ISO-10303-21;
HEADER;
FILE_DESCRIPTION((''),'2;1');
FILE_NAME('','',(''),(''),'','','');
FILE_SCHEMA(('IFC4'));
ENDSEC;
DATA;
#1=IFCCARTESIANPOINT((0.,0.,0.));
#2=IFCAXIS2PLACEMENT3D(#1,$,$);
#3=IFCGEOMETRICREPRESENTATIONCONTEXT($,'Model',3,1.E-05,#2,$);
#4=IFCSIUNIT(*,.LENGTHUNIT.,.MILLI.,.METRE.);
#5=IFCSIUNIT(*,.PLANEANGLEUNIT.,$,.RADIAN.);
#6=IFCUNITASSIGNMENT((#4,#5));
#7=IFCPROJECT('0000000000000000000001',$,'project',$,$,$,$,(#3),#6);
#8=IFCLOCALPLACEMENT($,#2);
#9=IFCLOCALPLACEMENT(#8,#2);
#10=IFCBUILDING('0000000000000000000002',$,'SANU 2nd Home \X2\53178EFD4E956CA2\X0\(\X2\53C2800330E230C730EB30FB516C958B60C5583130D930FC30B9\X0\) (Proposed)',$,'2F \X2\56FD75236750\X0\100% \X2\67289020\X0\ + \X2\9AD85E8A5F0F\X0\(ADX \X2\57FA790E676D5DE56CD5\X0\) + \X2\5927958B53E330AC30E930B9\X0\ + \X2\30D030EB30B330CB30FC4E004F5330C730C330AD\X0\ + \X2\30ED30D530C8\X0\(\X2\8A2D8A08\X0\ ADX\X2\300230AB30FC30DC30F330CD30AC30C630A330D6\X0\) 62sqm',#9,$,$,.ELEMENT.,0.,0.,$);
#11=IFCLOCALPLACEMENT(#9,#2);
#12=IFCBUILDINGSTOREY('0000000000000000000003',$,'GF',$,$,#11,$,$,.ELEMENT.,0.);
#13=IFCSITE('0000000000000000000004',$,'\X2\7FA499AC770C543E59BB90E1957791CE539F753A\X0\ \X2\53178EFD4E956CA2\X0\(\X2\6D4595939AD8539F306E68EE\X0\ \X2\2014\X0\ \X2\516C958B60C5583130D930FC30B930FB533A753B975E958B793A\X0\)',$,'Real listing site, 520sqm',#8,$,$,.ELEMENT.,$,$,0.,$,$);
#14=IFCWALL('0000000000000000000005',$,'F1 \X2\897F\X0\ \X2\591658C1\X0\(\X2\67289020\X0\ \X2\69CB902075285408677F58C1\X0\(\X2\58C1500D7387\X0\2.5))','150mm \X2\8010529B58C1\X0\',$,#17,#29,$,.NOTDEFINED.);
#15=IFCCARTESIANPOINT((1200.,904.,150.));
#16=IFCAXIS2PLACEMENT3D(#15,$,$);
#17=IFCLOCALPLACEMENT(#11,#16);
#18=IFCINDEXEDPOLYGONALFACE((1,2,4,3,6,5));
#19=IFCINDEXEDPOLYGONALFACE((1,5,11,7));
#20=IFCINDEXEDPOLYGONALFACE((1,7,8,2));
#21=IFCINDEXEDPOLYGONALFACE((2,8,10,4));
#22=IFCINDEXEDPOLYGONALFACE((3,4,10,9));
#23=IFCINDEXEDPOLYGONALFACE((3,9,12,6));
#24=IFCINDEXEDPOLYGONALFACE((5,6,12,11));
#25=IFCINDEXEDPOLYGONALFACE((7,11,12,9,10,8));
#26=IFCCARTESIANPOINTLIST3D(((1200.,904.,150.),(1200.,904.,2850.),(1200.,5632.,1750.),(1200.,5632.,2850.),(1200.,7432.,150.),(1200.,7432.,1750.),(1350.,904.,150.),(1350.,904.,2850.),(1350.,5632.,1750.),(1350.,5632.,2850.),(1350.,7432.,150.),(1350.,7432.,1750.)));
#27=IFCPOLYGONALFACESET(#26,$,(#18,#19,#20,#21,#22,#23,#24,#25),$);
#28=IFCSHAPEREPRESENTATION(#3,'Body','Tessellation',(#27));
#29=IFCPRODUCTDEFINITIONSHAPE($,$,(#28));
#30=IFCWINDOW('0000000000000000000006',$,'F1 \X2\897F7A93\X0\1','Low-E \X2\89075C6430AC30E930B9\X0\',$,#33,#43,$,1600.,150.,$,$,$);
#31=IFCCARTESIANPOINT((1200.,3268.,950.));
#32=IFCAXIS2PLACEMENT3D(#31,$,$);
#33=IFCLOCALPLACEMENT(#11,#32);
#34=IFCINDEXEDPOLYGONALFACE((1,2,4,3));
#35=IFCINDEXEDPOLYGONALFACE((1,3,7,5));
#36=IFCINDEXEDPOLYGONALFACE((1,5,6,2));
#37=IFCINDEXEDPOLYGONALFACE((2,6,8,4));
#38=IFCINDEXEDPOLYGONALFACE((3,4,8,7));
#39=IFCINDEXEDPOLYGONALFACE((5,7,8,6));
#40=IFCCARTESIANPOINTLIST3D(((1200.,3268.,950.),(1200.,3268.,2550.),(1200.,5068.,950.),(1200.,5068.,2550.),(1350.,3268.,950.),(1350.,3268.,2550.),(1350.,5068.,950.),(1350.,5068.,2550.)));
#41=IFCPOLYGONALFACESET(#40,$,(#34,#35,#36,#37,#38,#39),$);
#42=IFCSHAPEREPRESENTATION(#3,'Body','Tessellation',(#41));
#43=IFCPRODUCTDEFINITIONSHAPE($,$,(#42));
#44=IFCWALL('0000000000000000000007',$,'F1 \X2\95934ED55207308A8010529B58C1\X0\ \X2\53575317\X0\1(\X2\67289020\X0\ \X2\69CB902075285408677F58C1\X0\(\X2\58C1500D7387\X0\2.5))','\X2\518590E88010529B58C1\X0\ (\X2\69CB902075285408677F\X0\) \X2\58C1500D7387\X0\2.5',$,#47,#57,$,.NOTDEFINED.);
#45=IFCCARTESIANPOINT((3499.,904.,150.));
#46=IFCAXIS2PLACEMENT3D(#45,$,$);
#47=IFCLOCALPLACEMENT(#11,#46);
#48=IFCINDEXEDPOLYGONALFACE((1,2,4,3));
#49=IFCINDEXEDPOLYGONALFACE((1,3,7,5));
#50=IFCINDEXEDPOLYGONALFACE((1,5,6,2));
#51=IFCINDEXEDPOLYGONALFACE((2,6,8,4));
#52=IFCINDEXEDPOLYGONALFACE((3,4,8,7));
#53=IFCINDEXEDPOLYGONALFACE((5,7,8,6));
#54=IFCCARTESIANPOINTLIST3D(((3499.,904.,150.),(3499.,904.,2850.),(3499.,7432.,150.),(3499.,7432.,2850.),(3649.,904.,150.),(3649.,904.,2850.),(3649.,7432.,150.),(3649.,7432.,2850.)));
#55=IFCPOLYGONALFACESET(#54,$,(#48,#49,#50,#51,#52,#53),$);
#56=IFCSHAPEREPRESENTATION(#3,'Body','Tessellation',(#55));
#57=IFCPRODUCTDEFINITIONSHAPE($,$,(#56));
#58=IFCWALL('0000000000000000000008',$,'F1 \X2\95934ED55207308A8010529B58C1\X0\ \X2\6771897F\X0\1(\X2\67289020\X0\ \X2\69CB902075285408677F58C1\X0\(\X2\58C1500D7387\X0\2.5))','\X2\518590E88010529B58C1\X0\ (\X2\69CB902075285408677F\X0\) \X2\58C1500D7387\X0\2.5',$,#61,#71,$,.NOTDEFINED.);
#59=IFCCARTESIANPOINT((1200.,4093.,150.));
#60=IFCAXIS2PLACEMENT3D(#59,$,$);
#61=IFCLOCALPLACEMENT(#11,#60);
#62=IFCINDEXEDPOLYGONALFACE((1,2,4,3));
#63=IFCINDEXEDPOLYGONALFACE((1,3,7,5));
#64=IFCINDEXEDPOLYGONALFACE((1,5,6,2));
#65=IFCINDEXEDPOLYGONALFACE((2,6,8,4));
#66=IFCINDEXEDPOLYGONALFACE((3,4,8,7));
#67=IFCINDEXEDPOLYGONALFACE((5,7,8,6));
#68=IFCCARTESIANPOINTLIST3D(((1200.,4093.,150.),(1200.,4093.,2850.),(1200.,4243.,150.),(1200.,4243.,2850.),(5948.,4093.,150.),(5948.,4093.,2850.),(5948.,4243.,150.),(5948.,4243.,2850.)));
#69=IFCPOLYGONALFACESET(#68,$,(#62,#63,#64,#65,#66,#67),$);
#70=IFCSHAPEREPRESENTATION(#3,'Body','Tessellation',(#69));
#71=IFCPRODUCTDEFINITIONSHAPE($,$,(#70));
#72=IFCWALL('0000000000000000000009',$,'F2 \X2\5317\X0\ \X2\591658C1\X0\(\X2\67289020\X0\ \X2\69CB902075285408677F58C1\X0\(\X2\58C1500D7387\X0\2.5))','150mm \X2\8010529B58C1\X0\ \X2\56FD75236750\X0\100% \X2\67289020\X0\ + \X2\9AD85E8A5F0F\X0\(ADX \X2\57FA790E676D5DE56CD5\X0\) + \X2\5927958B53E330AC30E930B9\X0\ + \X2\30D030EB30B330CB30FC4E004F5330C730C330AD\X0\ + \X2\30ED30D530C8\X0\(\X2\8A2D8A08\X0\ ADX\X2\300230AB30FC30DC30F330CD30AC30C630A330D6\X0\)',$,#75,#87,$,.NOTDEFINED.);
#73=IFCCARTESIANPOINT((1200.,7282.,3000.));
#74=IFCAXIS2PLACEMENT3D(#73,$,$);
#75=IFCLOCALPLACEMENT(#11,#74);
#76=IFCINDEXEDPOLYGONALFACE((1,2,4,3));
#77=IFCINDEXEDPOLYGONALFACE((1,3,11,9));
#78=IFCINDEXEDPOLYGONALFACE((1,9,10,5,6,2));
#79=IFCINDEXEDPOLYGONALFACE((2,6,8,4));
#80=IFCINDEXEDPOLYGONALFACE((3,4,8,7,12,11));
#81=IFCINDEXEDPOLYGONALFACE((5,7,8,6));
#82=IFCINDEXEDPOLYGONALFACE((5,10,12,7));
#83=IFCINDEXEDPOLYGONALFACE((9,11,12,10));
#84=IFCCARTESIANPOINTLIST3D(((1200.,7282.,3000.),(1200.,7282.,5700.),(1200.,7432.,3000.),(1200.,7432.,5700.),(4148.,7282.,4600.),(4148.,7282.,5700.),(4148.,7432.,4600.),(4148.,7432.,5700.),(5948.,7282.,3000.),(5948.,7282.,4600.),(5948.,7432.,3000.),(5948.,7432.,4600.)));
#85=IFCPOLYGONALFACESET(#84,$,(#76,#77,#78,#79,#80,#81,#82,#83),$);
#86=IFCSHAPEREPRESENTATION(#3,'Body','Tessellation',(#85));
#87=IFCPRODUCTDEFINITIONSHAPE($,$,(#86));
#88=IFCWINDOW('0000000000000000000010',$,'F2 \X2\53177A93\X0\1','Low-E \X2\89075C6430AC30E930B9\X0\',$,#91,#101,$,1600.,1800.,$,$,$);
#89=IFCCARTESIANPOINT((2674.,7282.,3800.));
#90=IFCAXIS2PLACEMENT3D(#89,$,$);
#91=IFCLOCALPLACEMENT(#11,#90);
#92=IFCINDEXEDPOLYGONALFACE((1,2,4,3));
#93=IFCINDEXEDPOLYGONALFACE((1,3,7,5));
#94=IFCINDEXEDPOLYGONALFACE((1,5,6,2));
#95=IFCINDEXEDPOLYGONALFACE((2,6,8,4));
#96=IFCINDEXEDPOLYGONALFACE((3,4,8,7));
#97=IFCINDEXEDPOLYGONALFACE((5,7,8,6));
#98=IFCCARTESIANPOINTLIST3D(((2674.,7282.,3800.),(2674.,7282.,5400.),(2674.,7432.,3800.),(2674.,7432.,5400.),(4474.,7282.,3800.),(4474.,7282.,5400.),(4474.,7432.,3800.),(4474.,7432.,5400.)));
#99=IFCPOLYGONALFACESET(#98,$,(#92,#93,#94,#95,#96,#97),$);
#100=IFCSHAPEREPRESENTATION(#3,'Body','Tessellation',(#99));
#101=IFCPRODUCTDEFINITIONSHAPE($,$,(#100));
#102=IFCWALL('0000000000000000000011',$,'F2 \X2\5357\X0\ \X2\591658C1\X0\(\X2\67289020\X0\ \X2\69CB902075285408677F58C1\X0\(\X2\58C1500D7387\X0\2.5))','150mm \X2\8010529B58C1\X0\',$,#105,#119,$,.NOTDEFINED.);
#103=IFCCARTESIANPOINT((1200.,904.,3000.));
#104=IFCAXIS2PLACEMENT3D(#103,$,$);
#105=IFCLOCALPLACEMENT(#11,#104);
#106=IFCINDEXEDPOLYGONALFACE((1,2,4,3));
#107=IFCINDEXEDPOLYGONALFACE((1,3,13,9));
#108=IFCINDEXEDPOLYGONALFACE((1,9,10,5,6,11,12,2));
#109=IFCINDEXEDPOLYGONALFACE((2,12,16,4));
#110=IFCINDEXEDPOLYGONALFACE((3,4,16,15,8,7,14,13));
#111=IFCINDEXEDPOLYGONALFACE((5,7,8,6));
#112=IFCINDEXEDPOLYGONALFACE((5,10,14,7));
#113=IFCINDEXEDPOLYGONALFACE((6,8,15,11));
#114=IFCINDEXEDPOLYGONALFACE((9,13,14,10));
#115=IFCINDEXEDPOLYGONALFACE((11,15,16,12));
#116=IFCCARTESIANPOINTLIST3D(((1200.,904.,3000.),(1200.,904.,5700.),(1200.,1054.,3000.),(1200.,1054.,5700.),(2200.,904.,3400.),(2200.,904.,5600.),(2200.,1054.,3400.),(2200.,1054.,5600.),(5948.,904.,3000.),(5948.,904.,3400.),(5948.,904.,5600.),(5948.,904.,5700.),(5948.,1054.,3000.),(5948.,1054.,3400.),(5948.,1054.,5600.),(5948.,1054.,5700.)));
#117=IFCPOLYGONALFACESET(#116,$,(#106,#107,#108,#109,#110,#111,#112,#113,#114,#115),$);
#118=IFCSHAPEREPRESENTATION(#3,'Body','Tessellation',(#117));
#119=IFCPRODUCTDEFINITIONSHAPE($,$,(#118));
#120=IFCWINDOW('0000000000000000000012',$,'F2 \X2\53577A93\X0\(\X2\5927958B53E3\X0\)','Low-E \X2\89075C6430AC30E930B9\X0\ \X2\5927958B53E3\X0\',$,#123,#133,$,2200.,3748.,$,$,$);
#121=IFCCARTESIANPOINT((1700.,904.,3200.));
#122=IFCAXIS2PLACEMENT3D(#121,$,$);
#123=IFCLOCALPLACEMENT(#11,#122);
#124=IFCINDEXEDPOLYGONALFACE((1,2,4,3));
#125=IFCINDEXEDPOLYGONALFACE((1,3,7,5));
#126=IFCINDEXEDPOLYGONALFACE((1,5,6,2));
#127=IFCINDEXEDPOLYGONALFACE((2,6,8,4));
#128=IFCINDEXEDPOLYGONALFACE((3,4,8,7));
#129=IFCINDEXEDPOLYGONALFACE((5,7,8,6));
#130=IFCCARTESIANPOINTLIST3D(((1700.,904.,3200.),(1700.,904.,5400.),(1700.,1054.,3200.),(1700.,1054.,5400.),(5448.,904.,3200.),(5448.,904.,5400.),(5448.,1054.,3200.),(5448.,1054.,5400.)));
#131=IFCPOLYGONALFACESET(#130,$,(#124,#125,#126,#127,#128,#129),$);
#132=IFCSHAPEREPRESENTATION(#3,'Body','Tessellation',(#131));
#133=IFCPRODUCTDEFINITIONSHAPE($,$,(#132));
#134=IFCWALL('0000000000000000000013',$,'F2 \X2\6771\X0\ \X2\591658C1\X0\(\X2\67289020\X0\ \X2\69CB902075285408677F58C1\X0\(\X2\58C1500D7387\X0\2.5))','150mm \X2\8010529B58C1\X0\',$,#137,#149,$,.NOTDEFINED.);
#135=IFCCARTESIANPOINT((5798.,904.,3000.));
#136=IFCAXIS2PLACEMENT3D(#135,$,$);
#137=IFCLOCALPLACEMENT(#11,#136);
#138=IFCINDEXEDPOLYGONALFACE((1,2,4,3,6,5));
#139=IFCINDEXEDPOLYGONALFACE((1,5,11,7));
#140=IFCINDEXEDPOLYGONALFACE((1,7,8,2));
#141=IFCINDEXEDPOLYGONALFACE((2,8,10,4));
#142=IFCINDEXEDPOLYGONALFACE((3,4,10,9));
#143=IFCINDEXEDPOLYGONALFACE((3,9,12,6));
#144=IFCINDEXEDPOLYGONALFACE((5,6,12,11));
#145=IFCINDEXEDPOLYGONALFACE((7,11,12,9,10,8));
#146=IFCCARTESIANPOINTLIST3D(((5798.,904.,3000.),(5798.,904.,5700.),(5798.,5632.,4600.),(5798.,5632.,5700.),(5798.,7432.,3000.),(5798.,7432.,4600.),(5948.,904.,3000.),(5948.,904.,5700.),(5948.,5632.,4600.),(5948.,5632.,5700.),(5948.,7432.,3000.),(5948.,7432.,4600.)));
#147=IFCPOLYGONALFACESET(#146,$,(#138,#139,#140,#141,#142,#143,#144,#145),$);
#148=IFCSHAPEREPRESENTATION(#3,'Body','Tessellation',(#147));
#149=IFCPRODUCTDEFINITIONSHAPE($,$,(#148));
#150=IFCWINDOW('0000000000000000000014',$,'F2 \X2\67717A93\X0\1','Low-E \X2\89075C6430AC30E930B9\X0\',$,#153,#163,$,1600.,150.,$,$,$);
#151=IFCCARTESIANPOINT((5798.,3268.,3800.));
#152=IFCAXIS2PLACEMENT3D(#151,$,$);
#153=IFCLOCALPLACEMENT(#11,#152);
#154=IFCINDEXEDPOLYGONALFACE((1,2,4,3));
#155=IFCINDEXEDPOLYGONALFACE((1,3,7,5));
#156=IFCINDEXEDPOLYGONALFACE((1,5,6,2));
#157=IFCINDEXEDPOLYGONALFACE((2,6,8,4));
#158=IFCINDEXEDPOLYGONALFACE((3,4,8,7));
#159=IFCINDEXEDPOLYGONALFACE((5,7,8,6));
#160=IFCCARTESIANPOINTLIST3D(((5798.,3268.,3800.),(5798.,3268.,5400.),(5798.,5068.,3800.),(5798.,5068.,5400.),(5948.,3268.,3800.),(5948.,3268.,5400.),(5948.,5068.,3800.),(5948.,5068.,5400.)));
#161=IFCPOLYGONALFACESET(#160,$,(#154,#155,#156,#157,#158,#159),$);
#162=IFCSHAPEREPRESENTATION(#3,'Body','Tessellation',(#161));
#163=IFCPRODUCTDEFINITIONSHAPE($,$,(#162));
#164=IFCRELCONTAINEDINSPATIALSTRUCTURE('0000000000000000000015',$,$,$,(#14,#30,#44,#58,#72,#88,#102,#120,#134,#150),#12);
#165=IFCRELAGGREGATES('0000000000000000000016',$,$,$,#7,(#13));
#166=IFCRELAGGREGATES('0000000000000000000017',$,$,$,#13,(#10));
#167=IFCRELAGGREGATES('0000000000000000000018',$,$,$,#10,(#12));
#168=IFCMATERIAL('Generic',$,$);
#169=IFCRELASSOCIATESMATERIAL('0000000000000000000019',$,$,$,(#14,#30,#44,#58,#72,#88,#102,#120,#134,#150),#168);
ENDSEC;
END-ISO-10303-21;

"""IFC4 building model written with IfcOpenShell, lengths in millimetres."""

from ifc_helpers import new_model, si_unit, frame, frame_2d, origin, place, context, project, spatial, rectangle, extrude, material, element, fill, save


model = new_model("IFC4")

# Units and contexts
model_context = context("Model", 3, precision=1e-05, world=origin())
ifc_project = project(units=[si_unit("LENGTHUNIT", "METRE", prefix="MILLI"), si_unit("PLANEANGLEUNIT", "RADIAN")], contexts=[model_context])

# Site, building, storey
site_placement = place(None, origin())
site = spatial("IfcSite", under=ifc_project, at=site_placement, Name="群馬県吾妻郡長野原町 北軽井沢(浅間高原の森 — 公開情報ベース・区画非開示)", ObjectType="Real listing site, 520sqm", CompositionType="ELEMENT", RefElevation=0.0)
building_placement = place(site_placement, origin())
building = spatial("IfcBuilding", under=site, at=building_placement, Name="SANU 2nd Home 北軽井沢(参考モデル・公開情報ベース) (Proposed)", ObjectType="2F 国産材100% 木造 + 高床式(ADX 基礎杭工法) + 大開口ガラス + バルコニー一体デッキ + ロフト(設計 ADX。カーボンネガティブ) 62sqm", CompositionType="ELEMENT", ElevationOfRefHeight=0.0, ElevationOfTerrain=0.0)
storey_placement = place(building_placement, origin())
storey = spatial("IfcBuildingStorey", under=building, at=storey_placement, Name="GF", CompositionType="ELEMENT", Elevation=0.0)

# Shared definitions
ifc_material_1 = material(Name="Generic")

# Wall, opening, window
wall_1_placement = place(storey_placement, frame((1200.0, 904.0, 150.0)))
wall_1 = element("IfcWall", 1, at=wall_1_placement, inside=storey, material=ifc_material_1, Name="F1 西 外壁(木造 構造用合板壁(壁倍率2.5))", Description="150mm 耐力壁", PredefinedType="NOTDEFINED", context=model_context, shape_type="SweptSolid", body=[
    extrude(rectangle(XDim=150.0, YDim=6528.0, at=frame_2d((75.0, 3264.0))), frame((1200.0, 904.0, 150.0)), (0.0, 0.0, 1.0), 2700.0),
])
opening_1_placement = place(storey_placement, frame((1200.0, 3268.0, 950.0)))
opening_1 = element("IfcOpeningElement", 2, at=opening_1_placement, cuts=wall_1, PredefinedType="NOTDEFINED", context=model_context, shape_type="SweptSolid", body=[
    extrude(rectangle(XDim=150.0, YDim=1800.0, at=frame_2d((75.0, 900.0))), frame((1200.0, 3268.0, 950.0)), (0.0, 0.0, 1.0), 1600.0),
])
window_1_placement = place(storey_placement, frame((1200.0, 3268.0, 950.0)))
window_1 = element("IfcWindow", 3, at=window_1_placement, inside=storey, material=ifc_material_1, Name="F1 西窓1", Description="Low-E 複層ガラス", OverallHeight=1600.0, OverallWidth=150.0, context=model_context, shape_type="SweptSolid", body=[
    extrude(rectangle(XDim=150.0, YDim=1800.0, at=frame_2d((75.0, 900.0))), frame((1200.0, 3268.0, 950.0)), (0.0, 0.0, 1.0), 1600.0),
])
fill(opening_1, window_1)

# Walls
wall_2_placement = place(storey_placement, frame((3499.0, 904.0, 150.0)))
element("IfcWall", 4, at=wall_2_placement, inside=storey, material=ifc_material_1, Name="F1 間仕切り耐力壁 南北1(木造 構造用合板壁(壁倍率2.5))", Description="内部耐力壁 (構造用合板) 壁倍率2.5", PredefinedType="NOTDEFINED", context=model_context, shape_type="SweptSolid", body=[
    extrude(rectangle(XDim=150.0, YDim=6528.0, at=frame_2d((75.0, 3264.0))), frame((3499.0, 904.0, 150.0)), (0.0, 0.0, 1.0), 2700.0),
])
wall_3_placement = place(storey_placement, frame((1200.0, 4093.0, 150.0)))
element("IfcWall", 5, at=wall_3_placement, inside=storey, material=ifc_material_1, Name="F1 間仕切り耐力壁 東西1(木造 構造用合板壁(壁倍率2.5))", Description="内部耐力壁 (構造用合板) 壁倍率2.5", PredefinedType="NOTDEFINED", context=model_context, shape_type="SweptSolid", body=[
    extrude(rectangle(XDim=4748.0, YDim=150.0, at=frame_2d((2374.0, 75.0))), frame((1200.0, 4093.0, 150.0)), (0.0, 0.0, 1.0), 2700.0),
])

# Walls, openings, windows
wall_4_placement = place(storey_placement, frame((1200.0, 7282.0, 3000.0)))
wall_4 = element("IfcWall", 6, at=wall_4_placement, inside=storey, material=ifc_material_1, Name="F2 北 外壁(木造 構造用合板壁(壁倍率2.5))", Description="150mm 耐力壁 国産材100% 木造 + 高床式(ADX 基礎杭工法) + 大開口ガラス + バルコニー一体デッキ + ロフト(設計 ADX。カーボンネガティブ)", PredefinedType="NOTDEFINED", context=model_context, shape_type="SweptSolid", body=[
    extrude(rectangle(XDim=4748.0, YDim=150.0, at=frame_2d((2374.0, 75.0))), frame((1200.0, 7282.0, 3000.0)), (0.0, 0.0, 1.0), 2700.0),
])
opening_2_placement = place(storey_placement, frame((2674.0, 7282.0, 3800.0)))
opening_2 = element("IfcOpeningElement", 7, at=opening_2_placement, cuts=wall_4, PredefinedType="NOTDEFINED", context=model_context, shape_type="SweptSolid", body=[
    extrude(rectangle(XDim=1800.0, YDim=150.0, at=frame_2d((900.0, 75.0))), frame((2674.0, 7282.0, 3800.0)), (0.0, 0.0, 1.0), 1600.0),
])
window_2_placement = place(storey_placement, frame((2674.0, 7282.0, 3800.0)))
window_2 = element("IfcWindow", 8, at=window_2_placement, inside=storey, material=ifc_material_1, Name="F2 北窓1", Description="Low-E 複層ガラス", OverallHeight=1600.0, OverallWidth=1800.0, context=model_context, shape_type="SweptSolid", body=[
    extrude(rectangle(XDim=1800.0, YDim=150.0, at=frame_2d((900.0, 75.0))), frame((2674.0, 7282.0, 3800.0)), (0.0, 0.0, 1.0), 1600.0),
])
fill(opening_2, window_2)
wall_5_placement = place(storey_placement, frame((1200.0, 904.0, 3000.0)))
wall_5 = element("IfcWall", 9, at=wall_5_placement, inside=storey, material=ifc_material_1, Name="F2 南 外壁(木造 構造用合板壁(壁倍率2.5))", Description="150mm 耐力壁", PredefinedType="NOTDEFINED", context=model_context, shape_type="SweptSolid", body=[
    extrude(rectangle(XDim=4748.0, YDim=150.0, at=frame_2d((2374.0, 75.0))), frame((1200.0, 904.0, 3000.0)), (0.0, 0.0, 1.0), 2700.0),
])
opening_3_placement = place(storey_placement, frame((1700.0, 904.0, 3200.0)))
opening_3 = element("IfcOpeningElement", 10, at=opening_3_placement, cuts=wall_5, PredefinedType="NOTDEFINED", context=model_context, shape_type="SweptSolid", body=[
    extrude(rectangle(XDim=3748.0, YDim=150.0, at=frame_2d((1874.0, 75.0))), frame((1700.0, 904.0, 3200.0)), (0.0, 0.0, 1.0), 2200.0),
])
window_3_placement = place(storey_placement, frame((1700.0, 904.0, 3200.0)))
window_3 = element("IfcWindow", 11, at=window_3_placement, inside=storey, material=ifc_material_1, Name="F2 南窓(大開口)", Description="Low-E 複層ガラス 大開口", OverallHeight=2200.0, OverallWidth=3748.0, context=model_context, shape_type="SweptSolid", body=[
    extrude(rectangle(XDim=3748.0, YDim=150.0, at=frame_2d((1874.0, 75.0))), frame((1700.0, 904.0, 3200.0)), (0.0, 0.0, 1.0), 2200.0),
])
fill(opening_3, window_3)
wall_6_placement = place(storey_placement, frame((5798.0, 904.0, 3000.0)))
wall_6 = element("IfcWall", 12, at=wall_6_placement, inside=storey, material=ifc_material_1, Name="F2 東 外壁(木造 構造用合板壁(壁倍率2.5))", Description="150mm 耐力壁", PredefinedType="NOTDEFINED", context=model_context, shape_type="SweptSolid", body=[
    extrude(rectangle(XDim=150.0, YDim=6528.0, at=frame_2d((75.0, 3264.0))), frame((5798.0, 904.0, 3000.0)), (0.0, 0.0, 1.0), 2700.0),
])
opening_4_placement = place(storey_placement, frame((5798.0, 3268.0, 3800.0)))
opening_4 = element("IfcOpeningElement", 13, at=opening_4_placement, cuts=wall_6, PredefinedType="NOTDEFINED", context=model_context, shape_type="SweptSolid", body=[
    extrude(rectangle(XDim=150.0, YDim=1800.0, at=frame_2d((75.0, 900.0))), frame((5798.0, 3268.0, 3800.0)), (0.0, 0.0, 1.0), 1600.0),
])
window_4_placement = place(storey_placement, frame((5798.0, 3268.0, 3800.0)))
window_4 = element("IfcWindow", 14, at=window_4_placement, inside=storey, material=ifc_material_1, Name="F2 東窓1", Description="Low-E 複層ガラス", OverallHeight=1600.0, OverallWidth=150.0, context=model_context, shape_type="SweptSolid", body=[
    extrude(rectangle(XDim=150.0, YDim=1800.0, at=frame_2d((75.0, 900.0))), frame((5798.0, 3268.0, 3800.0)), (0.0, 0.0, 1.0), 1600.0),
])
fill(opening_4, window_4)

save(model, "model.ifc")
